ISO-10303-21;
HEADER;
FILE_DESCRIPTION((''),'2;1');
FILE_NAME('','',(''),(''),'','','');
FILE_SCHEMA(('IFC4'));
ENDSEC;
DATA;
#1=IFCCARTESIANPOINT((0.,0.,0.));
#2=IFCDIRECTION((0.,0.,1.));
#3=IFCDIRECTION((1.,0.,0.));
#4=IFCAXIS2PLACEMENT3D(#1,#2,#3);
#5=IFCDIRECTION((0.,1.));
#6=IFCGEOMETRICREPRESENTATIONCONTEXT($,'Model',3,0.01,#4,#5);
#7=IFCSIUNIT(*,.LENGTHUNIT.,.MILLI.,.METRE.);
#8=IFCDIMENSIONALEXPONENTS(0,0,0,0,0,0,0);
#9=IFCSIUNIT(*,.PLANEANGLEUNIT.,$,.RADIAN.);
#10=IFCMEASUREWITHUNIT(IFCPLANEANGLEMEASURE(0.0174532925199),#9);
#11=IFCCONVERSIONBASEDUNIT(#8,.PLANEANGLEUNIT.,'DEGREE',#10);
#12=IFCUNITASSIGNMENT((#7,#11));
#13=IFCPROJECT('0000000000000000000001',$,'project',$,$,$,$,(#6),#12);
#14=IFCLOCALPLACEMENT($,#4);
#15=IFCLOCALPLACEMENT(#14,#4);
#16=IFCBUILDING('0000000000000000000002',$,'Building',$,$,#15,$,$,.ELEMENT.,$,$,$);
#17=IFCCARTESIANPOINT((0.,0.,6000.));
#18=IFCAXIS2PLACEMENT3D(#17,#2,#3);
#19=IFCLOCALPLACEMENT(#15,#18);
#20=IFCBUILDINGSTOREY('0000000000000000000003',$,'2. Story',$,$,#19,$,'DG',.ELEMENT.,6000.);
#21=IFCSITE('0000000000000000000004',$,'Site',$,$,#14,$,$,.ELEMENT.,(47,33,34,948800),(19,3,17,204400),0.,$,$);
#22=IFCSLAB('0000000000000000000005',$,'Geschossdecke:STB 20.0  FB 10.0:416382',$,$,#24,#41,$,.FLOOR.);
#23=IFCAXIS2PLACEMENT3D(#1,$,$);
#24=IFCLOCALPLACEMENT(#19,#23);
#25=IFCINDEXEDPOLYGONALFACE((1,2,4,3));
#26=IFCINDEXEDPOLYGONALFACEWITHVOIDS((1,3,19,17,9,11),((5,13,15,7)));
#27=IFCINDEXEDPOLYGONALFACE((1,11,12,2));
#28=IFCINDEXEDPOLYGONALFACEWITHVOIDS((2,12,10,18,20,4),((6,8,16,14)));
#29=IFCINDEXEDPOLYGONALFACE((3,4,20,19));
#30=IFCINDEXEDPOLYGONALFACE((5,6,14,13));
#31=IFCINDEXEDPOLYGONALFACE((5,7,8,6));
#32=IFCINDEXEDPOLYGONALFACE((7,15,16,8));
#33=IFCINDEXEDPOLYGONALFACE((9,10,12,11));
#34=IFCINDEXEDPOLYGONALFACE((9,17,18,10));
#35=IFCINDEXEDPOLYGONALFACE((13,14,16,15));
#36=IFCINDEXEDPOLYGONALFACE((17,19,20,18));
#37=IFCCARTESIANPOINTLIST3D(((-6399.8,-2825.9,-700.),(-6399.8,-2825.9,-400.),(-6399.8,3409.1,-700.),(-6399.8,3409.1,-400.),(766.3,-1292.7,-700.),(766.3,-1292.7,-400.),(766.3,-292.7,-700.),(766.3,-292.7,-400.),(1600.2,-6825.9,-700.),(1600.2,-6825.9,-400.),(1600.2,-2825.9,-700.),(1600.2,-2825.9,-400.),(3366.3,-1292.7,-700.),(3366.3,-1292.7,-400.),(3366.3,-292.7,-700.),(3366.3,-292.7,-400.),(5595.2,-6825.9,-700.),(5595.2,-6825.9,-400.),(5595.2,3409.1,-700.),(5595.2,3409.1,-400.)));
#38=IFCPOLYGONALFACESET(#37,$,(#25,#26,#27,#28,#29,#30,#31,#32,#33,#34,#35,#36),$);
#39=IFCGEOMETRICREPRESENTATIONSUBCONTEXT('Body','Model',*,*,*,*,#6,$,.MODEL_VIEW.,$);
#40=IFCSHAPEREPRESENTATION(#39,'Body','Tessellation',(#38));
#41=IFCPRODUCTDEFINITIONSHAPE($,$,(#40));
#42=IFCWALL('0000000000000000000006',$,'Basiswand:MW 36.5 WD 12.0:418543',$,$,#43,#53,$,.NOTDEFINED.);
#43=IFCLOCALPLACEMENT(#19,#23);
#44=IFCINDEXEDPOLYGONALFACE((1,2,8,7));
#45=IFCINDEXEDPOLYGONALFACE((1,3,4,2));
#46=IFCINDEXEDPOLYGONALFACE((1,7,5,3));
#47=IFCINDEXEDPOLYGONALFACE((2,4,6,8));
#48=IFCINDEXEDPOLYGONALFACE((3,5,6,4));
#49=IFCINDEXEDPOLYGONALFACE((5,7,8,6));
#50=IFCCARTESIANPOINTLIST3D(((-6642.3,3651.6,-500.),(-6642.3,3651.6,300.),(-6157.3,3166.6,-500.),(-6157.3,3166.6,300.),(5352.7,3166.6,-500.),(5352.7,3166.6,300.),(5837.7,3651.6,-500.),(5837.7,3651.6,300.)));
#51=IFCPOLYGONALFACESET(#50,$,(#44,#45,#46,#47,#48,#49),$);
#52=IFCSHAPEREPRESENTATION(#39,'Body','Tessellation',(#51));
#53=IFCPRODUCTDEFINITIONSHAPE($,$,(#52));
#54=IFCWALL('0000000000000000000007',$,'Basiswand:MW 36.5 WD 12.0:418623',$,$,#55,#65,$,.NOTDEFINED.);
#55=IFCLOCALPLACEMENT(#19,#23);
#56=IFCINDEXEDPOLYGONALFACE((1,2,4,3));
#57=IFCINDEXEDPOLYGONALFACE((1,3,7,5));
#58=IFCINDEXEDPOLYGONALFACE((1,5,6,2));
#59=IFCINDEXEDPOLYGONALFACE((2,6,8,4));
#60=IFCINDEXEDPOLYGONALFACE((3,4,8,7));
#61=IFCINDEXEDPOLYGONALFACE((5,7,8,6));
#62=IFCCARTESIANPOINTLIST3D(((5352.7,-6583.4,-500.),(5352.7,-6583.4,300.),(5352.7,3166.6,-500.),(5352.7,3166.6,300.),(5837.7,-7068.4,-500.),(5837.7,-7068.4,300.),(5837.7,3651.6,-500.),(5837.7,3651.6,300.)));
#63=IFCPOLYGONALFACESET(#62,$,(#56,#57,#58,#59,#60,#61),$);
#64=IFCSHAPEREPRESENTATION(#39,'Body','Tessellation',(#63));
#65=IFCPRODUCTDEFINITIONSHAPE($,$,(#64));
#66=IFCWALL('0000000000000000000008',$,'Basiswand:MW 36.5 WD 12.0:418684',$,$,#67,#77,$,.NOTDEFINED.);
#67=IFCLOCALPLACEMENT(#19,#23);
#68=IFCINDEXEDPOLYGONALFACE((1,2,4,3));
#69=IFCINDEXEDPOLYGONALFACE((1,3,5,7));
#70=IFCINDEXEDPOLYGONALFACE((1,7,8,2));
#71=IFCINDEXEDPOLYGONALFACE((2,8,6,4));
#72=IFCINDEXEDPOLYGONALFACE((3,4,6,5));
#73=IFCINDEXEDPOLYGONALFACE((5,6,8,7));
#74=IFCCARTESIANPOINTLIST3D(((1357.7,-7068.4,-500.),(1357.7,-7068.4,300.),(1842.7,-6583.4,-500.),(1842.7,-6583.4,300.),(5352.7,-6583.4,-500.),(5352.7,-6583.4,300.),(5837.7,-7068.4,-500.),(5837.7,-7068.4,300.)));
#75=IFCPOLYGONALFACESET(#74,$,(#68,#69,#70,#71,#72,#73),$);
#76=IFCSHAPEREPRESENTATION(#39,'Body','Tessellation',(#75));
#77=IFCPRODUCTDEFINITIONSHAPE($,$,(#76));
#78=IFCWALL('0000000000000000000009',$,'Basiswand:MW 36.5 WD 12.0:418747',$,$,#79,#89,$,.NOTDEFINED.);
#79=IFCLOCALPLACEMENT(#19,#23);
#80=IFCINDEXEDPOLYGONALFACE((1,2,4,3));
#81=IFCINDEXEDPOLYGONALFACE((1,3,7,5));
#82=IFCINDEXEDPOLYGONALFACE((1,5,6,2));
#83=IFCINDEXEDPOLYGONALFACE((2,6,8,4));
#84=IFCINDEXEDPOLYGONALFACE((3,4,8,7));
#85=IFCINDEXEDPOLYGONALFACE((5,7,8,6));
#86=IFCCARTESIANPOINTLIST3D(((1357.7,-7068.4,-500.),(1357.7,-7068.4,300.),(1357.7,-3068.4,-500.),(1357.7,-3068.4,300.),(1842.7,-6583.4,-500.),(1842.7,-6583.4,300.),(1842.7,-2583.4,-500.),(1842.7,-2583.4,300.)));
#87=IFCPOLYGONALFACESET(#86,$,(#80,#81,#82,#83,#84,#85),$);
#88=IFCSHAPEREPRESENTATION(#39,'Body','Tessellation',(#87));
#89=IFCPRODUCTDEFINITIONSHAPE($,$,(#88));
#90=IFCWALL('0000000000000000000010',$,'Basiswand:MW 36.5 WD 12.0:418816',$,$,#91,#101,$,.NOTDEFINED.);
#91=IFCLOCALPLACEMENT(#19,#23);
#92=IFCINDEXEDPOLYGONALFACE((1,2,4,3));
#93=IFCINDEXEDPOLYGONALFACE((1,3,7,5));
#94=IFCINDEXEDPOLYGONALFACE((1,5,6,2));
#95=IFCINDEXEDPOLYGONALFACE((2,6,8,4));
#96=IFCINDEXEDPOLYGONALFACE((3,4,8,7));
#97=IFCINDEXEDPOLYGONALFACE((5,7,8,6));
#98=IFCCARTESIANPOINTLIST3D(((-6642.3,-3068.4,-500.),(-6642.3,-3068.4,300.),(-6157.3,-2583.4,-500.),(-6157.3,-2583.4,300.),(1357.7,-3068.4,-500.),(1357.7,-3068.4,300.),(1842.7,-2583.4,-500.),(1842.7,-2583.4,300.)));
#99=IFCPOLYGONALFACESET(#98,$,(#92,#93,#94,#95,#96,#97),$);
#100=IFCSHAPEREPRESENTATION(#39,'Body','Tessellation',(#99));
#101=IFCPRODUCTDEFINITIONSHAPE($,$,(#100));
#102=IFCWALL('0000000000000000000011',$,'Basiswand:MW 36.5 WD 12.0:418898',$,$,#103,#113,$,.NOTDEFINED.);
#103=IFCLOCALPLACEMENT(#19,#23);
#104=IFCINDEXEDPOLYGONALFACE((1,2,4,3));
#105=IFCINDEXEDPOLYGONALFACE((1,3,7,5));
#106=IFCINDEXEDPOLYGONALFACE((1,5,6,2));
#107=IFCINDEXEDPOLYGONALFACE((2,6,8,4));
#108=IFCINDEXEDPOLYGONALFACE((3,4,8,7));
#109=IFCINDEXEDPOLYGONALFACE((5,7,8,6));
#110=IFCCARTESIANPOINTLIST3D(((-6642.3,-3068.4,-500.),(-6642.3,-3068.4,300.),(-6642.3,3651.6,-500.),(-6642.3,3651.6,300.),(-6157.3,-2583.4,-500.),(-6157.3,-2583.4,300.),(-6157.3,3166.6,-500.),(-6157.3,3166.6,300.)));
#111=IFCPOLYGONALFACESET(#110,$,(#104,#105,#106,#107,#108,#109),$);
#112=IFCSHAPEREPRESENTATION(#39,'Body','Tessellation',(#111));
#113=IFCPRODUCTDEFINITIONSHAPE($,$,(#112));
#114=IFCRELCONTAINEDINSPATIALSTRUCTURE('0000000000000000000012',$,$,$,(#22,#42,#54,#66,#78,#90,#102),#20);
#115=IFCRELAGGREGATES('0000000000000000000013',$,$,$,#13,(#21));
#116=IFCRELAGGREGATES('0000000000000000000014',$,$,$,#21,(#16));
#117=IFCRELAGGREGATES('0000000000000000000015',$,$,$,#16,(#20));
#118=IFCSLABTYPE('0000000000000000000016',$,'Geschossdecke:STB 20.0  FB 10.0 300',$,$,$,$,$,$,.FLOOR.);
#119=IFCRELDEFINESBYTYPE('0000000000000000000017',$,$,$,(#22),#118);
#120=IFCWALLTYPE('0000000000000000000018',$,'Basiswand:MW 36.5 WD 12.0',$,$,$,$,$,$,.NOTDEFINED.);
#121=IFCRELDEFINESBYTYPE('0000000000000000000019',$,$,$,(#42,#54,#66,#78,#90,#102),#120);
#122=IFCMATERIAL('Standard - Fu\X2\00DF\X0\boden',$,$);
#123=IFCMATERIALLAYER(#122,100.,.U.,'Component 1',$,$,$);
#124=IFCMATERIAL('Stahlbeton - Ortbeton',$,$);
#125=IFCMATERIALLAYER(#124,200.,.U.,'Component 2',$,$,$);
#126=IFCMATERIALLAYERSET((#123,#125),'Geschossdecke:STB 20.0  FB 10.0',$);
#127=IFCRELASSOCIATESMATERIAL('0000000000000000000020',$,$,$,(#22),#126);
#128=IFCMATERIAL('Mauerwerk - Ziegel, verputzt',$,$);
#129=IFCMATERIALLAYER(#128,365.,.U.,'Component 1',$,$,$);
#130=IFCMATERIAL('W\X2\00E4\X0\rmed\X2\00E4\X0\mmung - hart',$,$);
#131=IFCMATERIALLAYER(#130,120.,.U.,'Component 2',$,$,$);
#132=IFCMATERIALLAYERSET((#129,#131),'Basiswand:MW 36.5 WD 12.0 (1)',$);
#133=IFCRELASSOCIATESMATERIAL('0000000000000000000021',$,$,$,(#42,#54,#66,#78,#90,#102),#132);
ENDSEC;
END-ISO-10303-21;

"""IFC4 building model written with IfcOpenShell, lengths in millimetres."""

from ifc_helpers import new_model, entity, si_unit, converted_unit, direction, frame, origin_with_axes, origin_2d_with_axis, place, context, subcontext, project, spatial, line, indexed_curve, rectangle, outline, extrude, material, layer, layer_set, layer_usage, type_object, element, save


model = new_model("IFC4")

# Units and contexts
model_context = context("Model", 3, precision=0.01, world=origin_with_axes(), true_north=direction((0.0, 1.0)))
body_context = subcontext(model_context, "Body", "Model", "MODEL_VIEW")
ifc_project = project(units=[si_unit("LENGTHUNIT", "METRE", prefix="MILLI"), converted_unit("PLANEANGLEUNIT", "DEGREE", entity("IfcPlaneAngleMeasure", 0.0174532925199), si_unit("PLANEANGLEUNIT", "RADIAN"), dimensions=[0, 0, 0, 0, 0, 0, 0])], contexts=[model_context])

# Site, building, storey
site_placement = place(None, origin_with_axes())
site = spatial("IfcSite", under=ifc_project, at=site_placement, Name="Site", CompositionType="ELEMENT", RefLatitude=(47, 33, 34, 948800), RefLongitude=(19, 3, 17, 204400), RefElevation=0.0)
building_placement = place(site_placement, origin_with_axes())
building = spatial("IfcBuilding", under=site, at=building_placement, Name="Building", CompositionType="ELEMENT")
storey_placement = place(building_placement, frame((0.0, 0.0, 6000.0), z_axis=(0.0, 0.0, 1.0), x_axis=(1.0, 0.0, 0.0)))
storey = spatial("IfcBuildingStorey", under=building, at=storey_placement, Name="2. Story", LongName="DG", CompositionType="ELEMENT", Elevation=6000.0)

# Slab, opening
ifc_material_1 = material(Name="Standard - Fußboden")
ifc_layer_1 = layer(ifc_material_1, 100.0, ventilated="UNKNOWN", Name="Component 1")
ifc_material_2 = material(Name="Stahlbeton - Ortbeton")
ifc_layer_2 = layer(ifc_material_2, 200.0, ventilated="UNKNOWN", Name="Component 2")
ifc_layer_set_1 = layer_set([ifc_layer_1, ifc_layer_2], Name="Geschossdecke:STB 20.0  FB 10.0")
ifc_layer_usage_1 = layer_usage(ifc_layer_set_1, "AXIS3", "NEGATIVE", 300.0)
slab_type = type_object("IfcSlabType", Name="Geschossdecke:STB 20.0  FB 10.0 300", PredefinedType="FLOOR")
slab_placement = place(storey_placement, frame((-6399.8, -2825.9, -700.0), z_axis=(0.0, 0.0, 1.0), x_axis=(1.0, 0.0, 0.0)))
slab = element("IfcSlab", 1, at=slab_placement, inside=storey, type_object=slab_type, material=ifc_layer_usage_1, Name="Geschossdecke:STB 20.0  FB 10.0:416382", PredefinedType="FLOOR", context=body_context, shape_type="SweptSolid", body=[
    extrude(outline(indexed_curve([(0.0, 0.0), (8000.0, 0.0), (8000.0, -4000.0), (11995.0, -4000.0), (11995.0, 6235.0), (0.0, 6235.0)], segments=[line(1, 2, 3, 4, 5, 6, 1)])), origin_with_axes(), (0.0, 0.0, 1.0), 300.0),
])
opening_placement = place(slab_placement, frame((6399.8, 2825.9, -5300.0), z_axis=(0.0, 0.0, 1.0), x_axis=(1.0, 0.0, 0.0)))
element("IfcOpeningElement", 2, at=opening_placement, cuts=slab, PredefinedType="OPENING", context=body_context, shape_type="SweptSolid", body=[
    extrude(rectangle(XDim=2600.0, YDim=1000.0, at=origin_2d_with_axis()), frame((2066.3, -792.7, 5600.0), z_axis=(0.0, 0.0, -1.0), x_axis=(1.0, 0.0, 0.0)), (0.0, 0.0, 1.0), 300.0),
])

# Walls
ifc_material_3 = material(Name="Mauerwerk - Ziegel, verputzt")
ifc_layer_3 = layer(ifc_material_3, 365.0, ventilated="UNKNOWN", Name="Component 1")
ifc_material_4 = material(Name="Wärmedämmung - hart")
ifc_layer_4 = layer(ifc_material_4, 120.0, ventilated="UNKNOWN", Name="Component 2")
ifc_layer_set_2 = layer_set([ifc_layer_3, ifc_layer_4], Name="Basiswand:MW 36.5 WD 12.0 (1)")
ifc_layer_usage_2 = layer_usage(ifc_layer_set_2, "AXIS2", "POSITIVE", -242.5)
wall_type = type_object("IfcWallType", Name="Basiswand:MW 36.5 WD 12.0", PredefinedType="NOTDEFINED")
wall_1_placement = place(storey_placement, frame((-6399.8, 3409.1, -500.0), z_axis=(0.0, 0.0, 1.0), x_axis=(1.0, 0.0, 0.0)))
element("IfcWall", 3, at=wall_1_placement, inside=storey, type_object=wall_type, material=ifc_layer_usage_2, Name="Basiswand:MW 36.5 WD 12.0:418543", PredefinedType="NOTDEFINED", context=body_context, shape_type="SweptSolid", body=[
    extrude(outline(indexed_curve([(242.5, -242.5), (11752.5, -242.5), (12237.5, 242.5), (-242.5, 242.5)], segments=[line(1, 2, 3, 4, 1)])), origin_with_axes(), (0.0, 0.0, 1.0), 800.0),
])
ifc_layer_usage_3 = layer_usage(ifc_layer_set_2, "AXIS2", "POSITIVE", -242.5)
wall_2_placement = place(storey_placement, frame((5595.2, 3409.1, -500.0), z_axis=(0.0, 0.0, 1.0), x_axis=(0.0, -1.0, 0.0)))
element("IfcWall", 4, at=wall_2_placement, inside=storey, type_object=wall_type, material=ifc_layer_usage_3, Name="Basiswand:MW 36.5 WD 12.0:418623", PredefinedType="NOTDEFINED", context=body_context, shape_type="SweptSolid", body=[
    extrude(outline(indexed_curve([(242.5, -242.5), (9992.5, -242.5), (10477.5, 242.5), (-242.5, 242.5)], segments=[line(1, 2, 3, 4, 1)])), origin_with_axes(), (0.0, 0.0, 1.0), 800.0),
])
ifc_layer_usage_4 = layer_usage(ifc_layer_set_2, "AXIS2", "POSITIVE", -242.5)
wall_3_placement = place(storey_placement, frame((5595.2, -6825.9, -500.0), z_axis=(0.0, 0.0, 1.0), x_axis=(-1.0, 0.0, 0.0)))
element("IfcWall", 5, at=wall_3_placement, inside=storey, type_object=wall_type, material=ifc_layer_usage_4, Name="Basiswand:MW 36.5 WD 12.0:418684", PredefinedType="NOTDEFINED", context=body_context, shape_type="SweptSolid", body=[
    extrude(outline(indexed_curve([(242.5, -242.5), (3752.5, -242.5), (4237.5, 242.5), (-242.5, 242.5)], segments=[line(1, 2, 3, 4, 1)])), origin_with_axes(), (0.0, 0.0, 1.0), 800.0),
])
ifc_layer_usage_5 = layer_usage(ifc_layer_set_2, "AXIS2", "POSITIVE", -242.5)
wall_4_placement = place(storey_placement, frame((1600.2, -6825.9, -500.0), z_axis=(0.0, 0.0, 1.0), x_axis=(0.0, 1.0, 0.0)))
element("IfcWall", 6, at=wall_4_placement, inside=storey, type_object=wall_type, material=ifc_layer_usage_5, Name="Basiswand:MW 36.5 WD 12.0:418747", PredefinedType="NOTDEFINED", context=body_context, shape_type="SweptSolid", body=[
    extrude(outline(indexed_curve([(242.5, -242.5), (4242.5, -242.5), (3757.5, 242.5), (-242.5, 242.5)], segments=[line(1, 2, 3, 4, 1)])), origin_with_axes(), (0.0, 0.0, 1.0), 800.0),
])
ifc_layer_usage_6 = layer_usage(ifc_layer_set_2, "AXIS2", "POSITIVE", -242.5)
wall_5_placement = place(storey_placement, frame((1600.2, -2825.9, -500.0), z_axis=(0.0, 0.0, 1.0), x_axis=(-1.0, 0.0, 0.0)))
element("IfcWall", 7, at=wall_5_placement, inside=storey, type_object=wall_type, material=ifc_layer_usage_6, Name="Basiswand:MW 36.5 WD 12.0:418816", PredefinedType="NOTDEFINED", context=body_context, shape_type="SweptSolid", body=[
    extrude(outline(indexed_curve([(-242.5, -242.5), (7757.5, -242.5), (8242.5, 242.5), (242.5, 242.5)], segments=[line(1, 2, 3, 4, 1)])), origin_with_axes(), (0.0, 0.0, 1.0), 800.0),
])
ifc_layer_usage_7 = layer_usage(ifc_layer_set_2, "AXIS2", "POSITIVE", -242.5)
wall_6_placement = place(storey_placement, frame((-6399.8, -2825.9, -500.0), z_axis=(0.0, 0.0, 1.0), x_axis=(0.0, 1.0, 0.0)))
element("IfcWall", 8, at=wall_6_placement, inside=storey, type_object=wall_type, material=ifc_layer_usage_7, Name="Basiswand:MW 36.5 WD 12.0:418898", PredefinedType="NOTDEFINED", context=body_context, shape_type="SweptSolid", body=[
    extrude(outline(indexed_curve([(242.5, -242.5), (5992.5, -242.5), (6477.5, 242.5), (-242.5, 242.5)], segments=[line(1, 2, 3, 4, 1)])), origin_with_axes(), (0.0, 0.0, 1.0), 800.0),
])

save(model, "model.ifc")
